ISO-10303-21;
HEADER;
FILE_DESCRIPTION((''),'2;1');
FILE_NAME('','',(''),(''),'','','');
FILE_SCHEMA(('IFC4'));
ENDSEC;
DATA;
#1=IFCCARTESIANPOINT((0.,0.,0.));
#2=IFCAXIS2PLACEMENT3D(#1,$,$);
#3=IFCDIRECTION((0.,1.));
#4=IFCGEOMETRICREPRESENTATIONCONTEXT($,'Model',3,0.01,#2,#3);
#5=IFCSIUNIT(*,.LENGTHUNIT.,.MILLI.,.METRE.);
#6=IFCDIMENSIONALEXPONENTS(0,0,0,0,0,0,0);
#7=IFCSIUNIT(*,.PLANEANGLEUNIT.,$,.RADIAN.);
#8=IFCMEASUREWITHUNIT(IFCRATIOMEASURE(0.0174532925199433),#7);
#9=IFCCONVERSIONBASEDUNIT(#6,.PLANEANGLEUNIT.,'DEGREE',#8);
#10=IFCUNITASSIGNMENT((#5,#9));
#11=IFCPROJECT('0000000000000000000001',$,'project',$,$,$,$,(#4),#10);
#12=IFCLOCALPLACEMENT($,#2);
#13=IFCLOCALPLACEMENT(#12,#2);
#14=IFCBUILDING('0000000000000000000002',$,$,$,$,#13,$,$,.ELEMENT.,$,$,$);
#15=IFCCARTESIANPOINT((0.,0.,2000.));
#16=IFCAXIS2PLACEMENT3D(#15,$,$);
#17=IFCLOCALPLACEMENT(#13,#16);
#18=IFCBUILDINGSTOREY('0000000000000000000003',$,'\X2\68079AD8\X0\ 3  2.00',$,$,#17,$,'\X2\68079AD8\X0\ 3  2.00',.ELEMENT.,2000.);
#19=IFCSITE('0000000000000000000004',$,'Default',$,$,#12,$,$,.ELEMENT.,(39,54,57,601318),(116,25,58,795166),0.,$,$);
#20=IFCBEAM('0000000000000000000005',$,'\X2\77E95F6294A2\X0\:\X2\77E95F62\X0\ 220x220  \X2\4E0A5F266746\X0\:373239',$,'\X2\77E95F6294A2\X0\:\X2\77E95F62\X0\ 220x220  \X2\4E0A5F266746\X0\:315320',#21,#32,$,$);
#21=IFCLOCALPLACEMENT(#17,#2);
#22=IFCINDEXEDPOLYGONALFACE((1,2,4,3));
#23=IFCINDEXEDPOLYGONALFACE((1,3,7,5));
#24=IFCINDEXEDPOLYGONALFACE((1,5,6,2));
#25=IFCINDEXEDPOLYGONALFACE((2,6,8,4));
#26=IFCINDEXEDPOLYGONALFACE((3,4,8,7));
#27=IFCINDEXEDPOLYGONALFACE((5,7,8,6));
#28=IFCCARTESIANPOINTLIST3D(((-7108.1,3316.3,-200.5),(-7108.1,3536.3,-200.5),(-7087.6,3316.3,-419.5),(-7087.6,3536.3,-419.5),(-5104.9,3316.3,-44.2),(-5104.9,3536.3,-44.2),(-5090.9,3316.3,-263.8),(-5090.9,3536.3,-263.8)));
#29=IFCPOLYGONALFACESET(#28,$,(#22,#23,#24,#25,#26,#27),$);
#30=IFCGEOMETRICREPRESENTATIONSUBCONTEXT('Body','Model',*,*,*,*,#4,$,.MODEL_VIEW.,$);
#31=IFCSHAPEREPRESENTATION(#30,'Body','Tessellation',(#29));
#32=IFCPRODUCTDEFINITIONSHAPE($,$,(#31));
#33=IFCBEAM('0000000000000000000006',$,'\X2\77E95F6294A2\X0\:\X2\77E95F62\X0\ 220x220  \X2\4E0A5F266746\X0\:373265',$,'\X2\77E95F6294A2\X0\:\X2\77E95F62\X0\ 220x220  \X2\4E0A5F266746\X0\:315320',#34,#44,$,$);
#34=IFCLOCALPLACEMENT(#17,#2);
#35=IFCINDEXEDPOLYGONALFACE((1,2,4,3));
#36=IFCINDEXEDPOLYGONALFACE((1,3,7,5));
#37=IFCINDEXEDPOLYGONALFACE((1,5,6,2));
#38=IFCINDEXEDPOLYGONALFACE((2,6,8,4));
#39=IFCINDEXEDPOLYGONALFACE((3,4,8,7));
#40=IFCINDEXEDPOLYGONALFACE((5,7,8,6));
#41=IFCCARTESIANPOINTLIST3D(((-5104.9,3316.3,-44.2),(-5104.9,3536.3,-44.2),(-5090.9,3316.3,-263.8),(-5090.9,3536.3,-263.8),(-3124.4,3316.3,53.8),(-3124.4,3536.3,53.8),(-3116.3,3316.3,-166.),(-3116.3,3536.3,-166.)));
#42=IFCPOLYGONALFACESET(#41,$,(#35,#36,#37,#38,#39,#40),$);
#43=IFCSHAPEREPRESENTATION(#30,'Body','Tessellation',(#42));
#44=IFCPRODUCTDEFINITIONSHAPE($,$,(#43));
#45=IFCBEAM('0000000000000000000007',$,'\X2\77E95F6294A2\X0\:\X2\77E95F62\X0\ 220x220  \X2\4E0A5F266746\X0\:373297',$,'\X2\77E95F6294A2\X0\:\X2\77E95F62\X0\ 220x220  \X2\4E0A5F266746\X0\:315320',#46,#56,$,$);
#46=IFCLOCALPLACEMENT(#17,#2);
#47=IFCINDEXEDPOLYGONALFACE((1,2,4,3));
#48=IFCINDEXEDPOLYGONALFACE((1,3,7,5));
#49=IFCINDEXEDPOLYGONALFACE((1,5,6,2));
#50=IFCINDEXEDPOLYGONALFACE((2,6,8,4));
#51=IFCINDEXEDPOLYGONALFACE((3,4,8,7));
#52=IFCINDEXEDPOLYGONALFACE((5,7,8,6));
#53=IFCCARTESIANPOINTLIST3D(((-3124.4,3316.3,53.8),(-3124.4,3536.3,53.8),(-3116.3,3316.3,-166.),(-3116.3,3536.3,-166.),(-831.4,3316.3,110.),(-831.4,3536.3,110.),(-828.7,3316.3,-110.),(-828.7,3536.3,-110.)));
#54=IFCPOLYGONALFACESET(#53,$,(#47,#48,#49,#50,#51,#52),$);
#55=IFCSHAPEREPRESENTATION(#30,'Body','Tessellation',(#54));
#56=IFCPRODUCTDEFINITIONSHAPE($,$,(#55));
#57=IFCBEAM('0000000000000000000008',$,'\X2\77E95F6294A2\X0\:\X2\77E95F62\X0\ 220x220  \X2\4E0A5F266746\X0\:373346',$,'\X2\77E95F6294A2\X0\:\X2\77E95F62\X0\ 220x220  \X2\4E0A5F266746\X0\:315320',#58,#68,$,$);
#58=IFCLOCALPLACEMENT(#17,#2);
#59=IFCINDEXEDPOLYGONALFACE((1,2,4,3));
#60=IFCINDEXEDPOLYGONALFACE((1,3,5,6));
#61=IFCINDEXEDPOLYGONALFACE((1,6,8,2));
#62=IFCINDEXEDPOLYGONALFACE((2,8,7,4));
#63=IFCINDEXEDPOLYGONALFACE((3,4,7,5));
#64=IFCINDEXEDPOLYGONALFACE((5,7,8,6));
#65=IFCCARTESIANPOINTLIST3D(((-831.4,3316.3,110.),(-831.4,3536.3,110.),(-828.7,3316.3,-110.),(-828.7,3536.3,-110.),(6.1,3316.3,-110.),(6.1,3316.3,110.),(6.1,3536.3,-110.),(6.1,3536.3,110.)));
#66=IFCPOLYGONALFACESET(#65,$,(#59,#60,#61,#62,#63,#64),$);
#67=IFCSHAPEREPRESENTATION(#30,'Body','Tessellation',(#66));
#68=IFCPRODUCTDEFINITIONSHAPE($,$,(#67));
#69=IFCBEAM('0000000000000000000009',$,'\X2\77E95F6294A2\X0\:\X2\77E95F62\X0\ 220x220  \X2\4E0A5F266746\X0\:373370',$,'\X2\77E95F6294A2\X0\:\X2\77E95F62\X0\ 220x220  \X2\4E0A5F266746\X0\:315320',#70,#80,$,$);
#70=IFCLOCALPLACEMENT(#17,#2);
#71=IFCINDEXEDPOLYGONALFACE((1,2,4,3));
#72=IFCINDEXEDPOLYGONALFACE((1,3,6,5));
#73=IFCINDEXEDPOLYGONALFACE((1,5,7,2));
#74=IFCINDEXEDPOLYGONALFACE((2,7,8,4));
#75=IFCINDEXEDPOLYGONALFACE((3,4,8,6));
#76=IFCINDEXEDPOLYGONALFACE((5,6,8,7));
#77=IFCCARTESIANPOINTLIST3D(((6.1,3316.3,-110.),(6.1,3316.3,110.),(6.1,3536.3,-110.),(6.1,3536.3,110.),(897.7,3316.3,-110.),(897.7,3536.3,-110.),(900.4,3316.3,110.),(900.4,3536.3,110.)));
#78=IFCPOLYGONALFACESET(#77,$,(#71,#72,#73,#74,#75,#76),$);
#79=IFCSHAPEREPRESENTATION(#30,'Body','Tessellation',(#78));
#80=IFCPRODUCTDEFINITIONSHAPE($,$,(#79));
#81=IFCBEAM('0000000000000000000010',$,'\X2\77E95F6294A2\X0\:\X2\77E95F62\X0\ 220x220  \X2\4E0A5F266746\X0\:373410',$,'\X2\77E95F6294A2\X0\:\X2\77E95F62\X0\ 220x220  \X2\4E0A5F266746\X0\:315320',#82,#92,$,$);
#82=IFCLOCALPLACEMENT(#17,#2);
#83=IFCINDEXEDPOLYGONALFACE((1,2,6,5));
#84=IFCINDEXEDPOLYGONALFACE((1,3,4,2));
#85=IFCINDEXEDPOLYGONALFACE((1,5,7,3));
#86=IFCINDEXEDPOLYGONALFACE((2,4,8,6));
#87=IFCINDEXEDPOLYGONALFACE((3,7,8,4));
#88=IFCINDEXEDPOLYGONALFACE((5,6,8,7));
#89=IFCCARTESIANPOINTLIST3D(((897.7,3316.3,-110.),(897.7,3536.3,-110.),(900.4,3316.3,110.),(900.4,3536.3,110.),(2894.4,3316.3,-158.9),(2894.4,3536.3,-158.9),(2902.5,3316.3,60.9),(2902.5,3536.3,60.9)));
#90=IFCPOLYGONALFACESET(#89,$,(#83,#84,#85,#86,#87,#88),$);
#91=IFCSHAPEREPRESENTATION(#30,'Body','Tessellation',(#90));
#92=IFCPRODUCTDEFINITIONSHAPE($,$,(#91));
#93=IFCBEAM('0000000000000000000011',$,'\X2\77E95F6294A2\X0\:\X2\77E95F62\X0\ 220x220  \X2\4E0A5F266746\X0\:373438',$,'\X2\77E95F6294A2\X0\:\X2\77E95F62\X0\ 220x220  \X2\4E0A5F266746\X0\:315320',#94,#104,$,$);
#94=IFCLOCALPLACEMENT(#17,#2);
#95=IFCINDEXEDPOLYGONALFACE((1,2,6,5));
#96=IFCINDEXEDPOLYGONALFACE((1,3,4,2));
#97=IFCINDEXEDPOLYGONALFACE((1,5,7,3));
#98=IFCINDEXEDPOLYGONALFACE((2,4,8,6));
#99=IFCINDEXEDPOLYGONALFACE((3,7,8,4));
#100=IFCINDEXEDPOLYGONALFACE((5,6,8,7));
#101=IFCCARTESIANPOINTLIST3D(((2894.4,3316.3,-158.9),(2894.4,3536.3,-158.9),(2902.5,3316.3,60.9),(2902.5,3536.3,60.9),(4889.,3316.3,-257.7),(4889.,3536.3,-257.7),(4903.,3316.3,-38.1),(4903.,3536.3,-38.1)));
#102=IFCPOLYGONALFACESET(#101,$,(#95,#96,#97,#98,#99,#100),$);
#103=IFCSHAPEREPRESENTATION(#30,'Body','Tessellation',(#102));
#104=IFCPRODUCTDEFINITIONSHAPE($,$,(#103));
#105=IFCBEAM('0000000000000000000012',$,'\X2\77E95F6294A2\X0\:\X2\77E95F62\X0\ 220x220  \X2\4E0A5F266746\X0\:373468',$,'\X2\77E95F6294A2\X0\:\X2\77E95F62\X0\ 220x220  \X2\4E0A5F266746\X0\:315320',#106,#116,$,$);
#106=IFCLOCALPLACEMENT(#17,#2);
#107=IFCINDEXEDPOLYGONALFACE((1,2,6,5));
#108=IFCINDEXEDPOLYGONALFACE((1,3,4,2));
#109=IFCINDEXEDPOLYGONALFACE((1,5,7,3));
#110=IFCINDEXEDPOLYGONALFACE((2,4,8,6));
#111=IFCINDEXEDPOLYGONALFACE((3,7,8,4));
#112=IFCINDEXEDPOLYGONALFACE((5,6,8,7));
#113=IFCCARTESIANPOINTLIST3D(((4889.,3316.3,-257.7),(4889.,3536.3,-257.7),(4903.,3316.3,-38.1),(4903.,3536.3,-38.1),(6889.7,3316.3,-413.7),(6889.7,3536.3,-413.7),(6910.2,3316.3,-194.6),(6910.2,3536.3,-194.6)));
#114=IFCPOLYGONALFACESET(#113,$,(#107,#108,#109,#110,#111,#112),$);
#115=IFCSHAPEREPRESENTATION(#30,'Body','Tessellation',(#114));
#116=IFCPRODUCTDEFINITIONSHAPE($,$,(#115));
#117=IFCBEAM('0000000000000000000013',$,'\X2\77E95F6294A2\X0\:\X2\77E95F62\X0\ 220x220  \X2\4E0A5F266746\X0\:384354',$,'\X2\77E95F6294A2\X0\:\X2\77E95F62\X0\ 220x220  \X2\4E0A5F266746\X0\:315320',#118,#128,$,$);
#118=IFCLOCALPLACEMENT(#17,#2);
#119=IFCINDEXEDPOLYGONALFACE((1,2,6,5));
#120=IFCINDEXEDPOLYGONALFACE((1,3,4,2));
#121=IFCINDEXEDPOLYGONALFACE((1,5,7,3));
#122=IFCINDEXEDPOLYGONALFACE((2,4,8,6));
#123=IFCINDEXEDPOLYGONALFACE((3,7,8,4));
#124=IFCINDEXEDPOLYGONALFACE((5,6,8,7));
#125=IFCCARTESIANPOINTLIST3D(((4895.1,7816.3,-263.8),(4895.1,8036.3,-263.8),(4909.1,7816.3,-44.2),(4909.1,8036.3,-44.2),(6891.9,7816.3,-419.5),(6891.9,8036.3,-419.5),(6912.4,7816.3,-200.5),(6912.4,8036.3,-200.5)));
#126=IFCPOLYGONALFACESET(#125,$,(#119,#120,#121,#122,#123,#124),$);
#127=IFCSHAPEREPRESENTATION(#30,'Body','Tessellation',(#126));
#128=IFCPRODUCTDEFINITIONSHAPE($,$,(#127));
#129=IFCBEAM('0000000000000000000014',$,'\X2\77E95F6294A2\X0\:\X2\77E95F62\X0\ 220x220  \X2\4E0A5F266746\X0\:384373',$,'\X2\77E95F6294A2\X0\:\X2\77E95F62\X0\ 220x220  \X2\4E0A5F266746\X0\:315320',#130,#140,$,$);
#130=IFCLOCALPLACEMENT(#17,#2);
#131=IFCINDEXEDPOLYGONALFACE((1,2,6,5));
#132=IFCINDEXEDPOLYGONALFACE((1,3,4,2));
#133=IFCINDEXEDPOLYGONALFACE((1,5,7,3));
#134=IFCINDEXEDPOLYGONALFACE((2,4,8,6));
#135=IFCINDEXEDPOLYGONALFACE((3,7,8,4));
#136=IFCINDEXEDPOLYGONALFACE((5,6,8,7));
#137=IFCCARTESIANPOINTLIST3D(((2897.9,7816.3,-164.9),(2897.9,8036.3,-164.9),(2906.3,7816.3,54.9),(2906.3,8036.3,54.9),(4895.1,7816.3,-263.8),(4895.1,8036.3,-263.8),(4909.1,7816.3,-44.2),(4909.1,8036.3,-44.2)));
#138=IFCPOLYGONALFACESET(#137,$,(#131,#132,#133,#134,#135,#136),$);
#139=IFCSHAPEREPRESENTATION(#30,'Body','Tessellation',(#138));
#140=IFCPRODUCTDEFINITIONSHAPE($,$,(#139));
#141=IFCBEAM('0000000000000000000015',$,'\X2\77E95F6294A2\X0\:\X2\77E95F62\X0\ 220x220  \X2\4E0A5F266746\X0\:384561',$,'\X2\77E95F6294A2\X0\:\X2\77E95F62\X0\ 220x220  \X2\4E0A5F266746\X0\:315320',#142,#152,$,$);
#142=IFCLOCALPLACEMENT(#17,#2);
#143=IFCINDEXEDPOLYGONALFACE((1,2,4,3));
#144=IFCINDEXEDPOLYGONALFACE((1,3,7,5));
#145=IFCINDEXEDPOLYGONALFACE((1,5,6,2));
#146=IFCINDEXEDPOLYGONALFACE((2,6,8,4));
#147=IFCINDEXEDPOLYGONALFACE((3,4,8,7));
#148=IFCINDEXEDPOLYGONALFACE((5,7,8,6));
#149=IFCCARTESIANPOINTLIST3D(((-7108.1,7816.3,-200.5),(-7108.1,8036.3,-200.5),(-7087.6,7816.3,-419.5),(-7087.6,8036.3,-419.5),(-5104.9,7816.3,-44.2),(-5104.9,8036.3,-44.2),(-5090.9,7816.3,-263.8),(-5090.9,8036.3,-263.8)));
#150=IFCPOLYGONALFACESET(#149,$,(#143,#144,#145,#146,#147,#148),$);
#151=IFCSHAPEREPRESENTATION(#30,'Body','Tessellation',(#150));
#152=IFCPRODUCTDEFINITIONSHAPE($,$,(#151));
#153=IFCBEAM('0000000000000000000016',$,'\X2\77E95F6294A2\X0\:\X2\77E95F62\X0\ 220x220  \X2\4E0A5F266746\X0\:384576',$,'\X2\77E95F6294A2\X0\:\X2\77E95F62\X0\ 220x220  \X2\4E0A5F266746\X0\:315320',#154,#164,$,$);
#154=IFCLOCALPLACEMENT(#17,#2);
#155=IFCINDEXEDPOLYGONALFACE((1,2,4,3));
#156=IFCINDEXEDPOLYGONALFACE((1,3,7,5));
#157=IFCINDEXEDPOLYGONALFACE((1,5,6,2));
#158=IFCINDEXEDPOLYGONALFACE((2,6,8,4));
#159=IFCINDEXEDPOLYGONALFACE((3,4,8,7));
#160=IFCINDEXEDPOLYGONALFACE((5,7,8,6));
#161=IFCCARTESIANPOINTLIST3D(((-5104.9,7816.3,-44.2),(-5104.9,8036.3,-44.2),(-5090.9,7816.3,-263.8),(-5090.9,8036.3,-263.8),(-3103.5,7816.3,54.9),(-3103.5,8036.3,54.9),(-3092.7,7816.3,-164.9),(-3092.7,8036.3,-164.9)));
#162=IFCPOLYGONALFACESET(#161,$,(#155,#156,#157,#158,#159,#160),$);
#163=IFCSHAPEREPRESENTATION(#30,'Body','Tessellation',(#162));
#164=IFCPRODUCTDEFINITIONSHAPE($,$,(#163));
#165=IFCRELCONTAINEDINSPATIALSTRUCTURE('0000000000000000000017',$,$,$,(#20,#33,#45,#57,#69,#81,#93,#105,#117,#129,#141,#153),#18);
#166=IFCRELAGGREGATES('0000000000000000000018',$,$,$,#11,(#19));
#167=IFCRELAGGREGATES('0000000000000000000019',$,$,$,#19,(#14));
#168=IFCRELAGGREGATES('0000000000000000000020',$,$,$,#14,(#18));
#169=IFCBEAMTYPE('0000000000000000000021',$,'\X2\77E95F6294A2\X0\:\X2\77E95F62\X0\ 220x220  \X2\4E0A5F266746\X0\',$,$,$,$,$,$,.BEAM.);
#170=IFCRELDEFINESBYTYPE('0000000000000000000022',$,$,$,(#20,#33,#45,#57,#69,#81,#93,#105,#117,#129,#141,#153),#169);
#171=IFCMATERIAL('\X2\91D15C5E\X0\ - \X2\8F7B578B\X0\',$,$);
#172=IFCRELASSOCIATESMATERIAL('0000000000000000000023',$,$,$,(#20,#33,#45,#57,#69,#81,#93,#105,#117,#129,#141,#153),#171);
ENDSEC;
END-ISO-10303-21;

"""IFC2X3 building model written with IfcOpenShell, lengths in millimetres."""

from ifc_helpers import new_model, entity, si_unit, converted_unit, direction, frame, frame_2d, origin, origin_2d_with_axis, place, context, subcontext, project, spatial, rectangle, extrude, clip, halfspace, material, type_object, element, save


model = new_model("IFC2X3")

# Units and contexts
model_context = context("Model", 3, precision=0.01, world=origin(), true_north=direction((0.0, 1.0)))
body_context = subcontext(model_context, "Body", "Model", "MODEL_VIEW")
ifc_project = project(units=[si_unit("LENGTHUNIT", "METRE", prefix="MILLI"), converted_unit("PLANEANGLEUNIT", "DEGREE", entity("IfcRatioMeasure", 0.0174532925199433), si_unit("PLANEANGLEUNIT", "RADIAN"), dimensions=[0, 0, 0, 0, 0, 0, 0])], contexts=[model_context])

# Site, building, storey
site_placement = place(None, origin())
site = spatial("IfcSite", under=ifc_project, at=site_placement, Name="Default", CompositionType="ELEMENT", RefLatitude=(39, 54, 57, 601318), RefLongitude=(116, 25, 58, 795166), RefElevation=0.0)
building_placement = place(site_placement, origin())
building = spatial("IfcBuilding", under=site, at=building_placement, CompositionType="ELEMENT")
storey_placement = place(building_placement, frame((0.0, 0.0, 2000.0)))
storey = spatial("IfcBuildingStorey", under=building, at=storey_placement, Name="标高 3  2.00", LongName="标高 3  2.00", CompositionType="ELEMENT", Elevation=2000.0)

# Beams
ifc_material = material(Name="金属 - 轻型")
beam_type = type_object("IfcBeamType", Name="矩形钢:矩形 220x220  上弦杆", PredefinedType="BEAM")
beam_1_placement = place(storey_placement, frame((-7097.9, 3426.3, -310.0), z_axis=(-0.077764, 0.0, 0.996972), x_axis=(0.996972, 0.0, 0.077764)))
element("IfcBeam", 1, at=beam_1_placement, inside=storey, type_object=beam_type, material=ifc_material, Name="矩形钢:矩形 220x220  上弦杆:373239", ObjectType="矩形钢:矩形 220x220  上弦杆:315320", context=body_context, shape_type="Clipping", body=[
    clip(clip(extrude(rectangle(XDim=220.0, YDim=220.0, at=frame_2d((0.0, 0.0), x_axis=(1.0, 0.0))), frame((-1.7, 0.0, 0.0), z_axis=(1.0, 0.0, 0.0), x_axis=(0.0, 0.0, -1.0)), (0.0, 0.0, 1.0), 2009.3), halfspace(frame((2007.6, 0.0, 110.0), z_axis=(0.999899, 0.0, -0.014191), x_axis=(-0.014191, 0.0, -0.999899)), False)), halfspace(frame((-1.7, 0.0, 110.0), z_axis=(-0.999878, 0.0, -0.015611), x_axis=(0.015611, 0.0, -0.999878)), False)),
])
beam_2_placement = place(storey_placement, frame((-5097.9, 3426.3, -154.0), z_axis=(-0.049439, 0.0, 0.998777), x_axis=(0.998777, 0.0, 0.049439)))
element("IfcBeam", 2, at=beam_2_placement, inside=storey, type_object=beam_type, material=ifc_material, Name="矩形钢:矩形 220x220  上弦杆:373265", ObjectType="矩形钢:矩形 220x220  上弦杆:315320", context=body_context, shape_type="Clipping", body=[
    clip(clip(extrude(rectangle(XDim=220.0, YDim=220.0, at=frame_2d((0.0, 0.0), x_axis=(1.0, 0.0))), frame((-1.6, 0.0, 0.0), z_axis=(1.0, 0.0, 0.0), x_axis=(0.0, 0.0, -1.0)), (0.0, 0.0, 1.0), 1982.9), halfspace(frame((1981.4, 0.0, 110.0), z_axis=(0.999922, 0.0, -0.012482), x_axis=(-0.012482, 0.0, -0.999922)), False)), halfspace(frame((-1.6, 0.0, 110.0), z_axis=(-0.999899, 0.0, -0.014191), x_axis=(0.014191, 0.0, -0.999899)), False)),
])
beam_3_placement = place(storey_placement, frame((-3120.3, 3426.3, -56.1), z_axis=(-0.024493, 0.0, 0.9997), x_axis=(0.9997, 0.0, 0.024493)))
element("IfcBeam", 3, at=beam_3_placement, inside=storey, type_object=beam_type, material=ifc_material, Name="矩形钢:矩形 220x220  上弦杆:373297", ObjectType="矩形钢:矩形 220x220  上弦杆:315320", context=body_context, shape_type="Clipping", body=[
    clip(clip(extrude(rectangle(XDim=220.0, YDim=220.0, at=frame_2d((0.0, 0.0), x_axis=(1.0, 0.0))), frame((-1.4, 0.0, 0.0), z_axis=(1.0, 0.0, 0.0), x_axis=(0.0, 0.0, -1.0)), (0.0, 0.0, 1.0), 2293.7), halfspace(frame((2292.4, 0.0, 110.0), z_axis=(0.999925, 0.0, -0.012247), x_axis=(-0.012247, 0.0, -0.999925)), False)), halfspace(frame((-1.4, 0.0, 110.0), z_axis=(-0.999922, 0.0, -0.012482), x_axis=(0.012482, 0.0, -0.999922)), False)),
])
beam_4_placement = place(storey_placement, frame((-1100.9, 3426.3, 0.0)))
element("IfcBeam", 4, at=beam_4_placement, inside=storey, type_object=beam_type, material=ifc_material, Name="矩形钢:矩形 220x220  上弦杆:373346", ObjectType="矩形钢:矩形 220x220  上弦杆:315320", context=body_context, shape_type="Clipping", body=[
    clip(extrude(rectangle(XDim=220.0, YDim=220.0, at=frame_2d((0.0, 0.0), x_axis=(1.0, 0.0))), frame((269.6, 0.0, 0.0), z_axis=(1.0, 0.0, 0.0), x_axis=(0.0, 0.0, -1.0)), (0.0, 0.0, 1.0), 837.4), halfspace(frame((269.6, 0.0, 110.0), z_axis=(-0.999925, 0.0, -0.012247), x_axis=(0.012247, 0.0, -0.999925)), False)),
])
beam_5_placement = place(storey_placement, frame((-80.9, 3426.3, 0.0)))
element("IfcBeam", 5, at=beam_5_placement, inside=storey, type_object=beam_type, material=ifc_material, Name="矩形钢:矩形 220x220  上弦杆:373370", ObjectType="矩形钢:矩形 220x220  上弦杆:315320", context=body_context, shape_type="Clipping", body=[
    clip(extrude(rectangle(XDim=220.0, YDim=220.0, at=frame_2d((0.0, 0.0), x_axis=(1.0, 0.0))), frame((87.0, 0.0, 0.0), z_axis=(1.0, 0.0, 0.0), x_axis=(0.0, 0.0, -1.0)), (0.0, 0.0, 1.0), 894.3), halfspace(frame((981.3, 0.0, 110.0), z_axis=(0.999925, 0.0, -0.012247), x_axis=(0.012247, 0.0, 0.999925)), False)),
])
beam_6_placement = place(storey_placement, frame((899.1, 3426.3, 0.0), z_axis=(0.024493, 0.0, 0.9997), x_axis=(0.9997, 0.0, -0.024493)))
element("IfcBeam", 6, at=beam_6_placement, inside=storey, type_object=beam_type, material=ifc_material, Name="矩形钢:矩形 220x220  上弦杆:373410", ObjectType="矩形钢:矩形 220x220  上弦杆:315320", context=body_context, shape_type="Clipping", body=[
    clip(clip(extrude(rectangle(XDim=220.0, YDim=220.0, at=frame_2d((0.0, 0.0), x_axis=(1.0, 0.0))), frame((-1.3, 0.0, 0.0), z_axis=(1.0, 0.0, 0.0), x_axis=(0.0, 0.0, -1.0)), (0.0, 0.0, 1.0), 2002.7), halfspace(frame((2001.4, 0.0, 110.0), z_axis=(0.999922, 0.0, -0.012482), x_axis=(0.012482, 0.0, 0.999922)), False)), halfspace(frame((-1.3, 0.0, 110.0), z_axis=(-0.999925, 0.0, -0.012247), x_axis=(-0.012247, 0.0, 0.999925)), False)),
])
beam_7_placement = place(storey_placement, frame((2898.5, 3426.3, -49.0), z_axis=(0.049439, 0.0, 0.998777), x_axis=(0.998777, 0.0, -0.049439)))
element("IfcBeam", 7, at=beam_7_placement, inside=storey, type_object=beam_type, material=ifc_material, Name="矩形钢:矩形 220x220  上弦杆:373438", ObjectType="矩形钢:矩形 220x220  上弦杆:315320", context=body_context, shape_type="Clipping", body=[
    clip(clip(extrude(rectangle(XDim=220.0, YDim=220.0, at=frame_2d((0.0, 0.0), x_axis=(1.0, 0.0))), frame((-1.4, 0.0, 0.0), z_axis=(1.0, 0.0, 0.0), x_axis=(0.0, 0.0, -1.0)), (0.0, 0.0, 1.0), 2002.9), halfspace(frame((2001.6, 0.0, 110.0), z_axis=(0.999899, 0.0, -0.014191), x_axis=(0.014191, 0.0, 0.999899)), False)), halfspace(frame((-1.4, 0.0, 110.0), z_axis=(-0.999922, 0.0, -0.012482), x_axis=(-0.012482, 0.0, 0.999922)), False)),
])
beam_8_placement = place(storey_placement, frame((4896.0, 3426.3, -147.9), z_axis=(0.077764, 0.0, 0.996972), x_axis=(0.996972, 0.0, -0.077764)))
element("IfcBeam", 8, at=beam_8_placement, inside=storey, type_object=beam_type, material=ifc_material, Name="矩形钢:矩形 220x220  上弦杆:373468", ObjectType="矩形钢:矩形 220x220  上弦杆:315320", context=body_context, shape_type="Clipping", body=[
    clip(clip(extrude(rectangle(XDim=220.0, YDim=220.0, at=frame_2d((0.0, 0.0), x_axis=(1.0, 0.0))), frame((-1.6, 0.0, 0.0), z_axis=(1.0, 0.0, 0.0), x_axis=(0.0, 0.0, -1.0)), (0.0, 0.0, 1.0), 2013.3), halfspace(frame((2011.7, 0.0, 110.0), z_axis=(0.999878, 0.0, -0.015611), x_axis=(0.015611, 0.0, 0.999878)), False)), halfspace(frame((-1.6, 0.0, 110.0), z_axis=(-0.999899, 0.0, -0.014191), x_axis=(-0.014191, 0.0, 0.999899)), False)),
])
beam_9_placement = place(storey_placement, frame((6902.1, 7926.3, -310.0), z_axis=(0.077764, 0.0, 0.996972), x_axis=(-0.996972, 0.0, 0.077764)))
element("IfcBeam", 9, at=beam_9_placement, inside=storey, type_object=beam_type, material=ifc_material, Name="矩形钢:矩形 220x220  上弦杆:384354", ObjectType="矩形钢:矩形 220x220  上弦杆:315320", context=body_context, shape_type="Clipping", body=[
    clip(clip(extrude(rectangle(XDim=220.0, YDim=220.0, at=origin_2d_with_axis()), frame((-1.7, 0.0, 0.0), z_axis=(1.0, 0.0, 0.0), x_axis=(0.0, 0.0, -1.0)), (0.0, 0.0, 1.0), 2009.4), halfspace(frame((-1.7, 0.0, 110.0), z_axis=(-0.999878, 0.0, -0.015611), x_axis=(-0.015611, 0.0, 0.999878)), False)), halfspace(frame((2007.6, 0.0, 110.0), z_axis=(0.999899, 0.0, -0.014191), x_axis=(0.014191, 0.0, 0.999899)), False)),
])
beam_10_placement = place(storey_placement, frame((4902.1, 7926.3, -154.0), z_axis=(0.049439, 0.0, 0.998777), x_axis=(-0.998777, 0.0, 0.049439)))
element("IfcBeam", 10, at=beam_10_placement, inside=storey, type_object=beam_type, material=ifc_material, Name="矩形钢:矩形 220x220  上弦杆:384373", ObjectType="矩形钢:矩形 220x220  上弦杆:315320", context=body_context, shape_type="Clipping", body=[
    clip(clip(extrude(rectangle(XDim=220.0, YDim=220.0, at=frame_2d((0.0, 0.0), x_axis=(1.0, 0.0))), frame((-1.6, 0.0, 0.0), z_axis=(1.0, 0.0, 0.0), x_axis=(0.0, 0.0, -1.0)), (0.0, 0.0, 1.0), 2005.2), halfspace(frame((2001.2, 0.0, -110.0), z_axis=(0.999937, 0.0, -0.01122), x_axis=(0.01122, 0.0, 0.999937)), False)), halfspace(frame((-1.6, 0.0, 110.0), z_axis=(-0.999899, 0.0, -0.014191), x_axis=(-0.014191, 0.0, 0.999899)), False)),
])
beam_11_placement = place(storey_placement, frame((-7097.9, 7926.3, -310.0), z_axis=(-0.077764, 0.0, 0.996972), x_axis=(0.996972, 0.0, 0.077764)))
element("IfcBeam", 11, at=beam_11_placement, inside=storey, type_object=beam_type, material=ifc_material, Name="矩形钢:矩形 220x220  上弦杆:384561", ObjectType="矩形钢:矩形 220x220  上弦杆:315320", context=body_context, shape_type="Clipping", body=[
    clip(clip(extrude(rectangle(XDim=220.0, YDim=220.0, at=frame_2d((0.0, 0.0), x_axis=(1.0, 0.0))), frame((-1.7, 0.0, 0.0), z_axis=(1.0, 0.0, 0.0), x_axis=(0.0, 0.0, -1.0)), (0.0, 0.0, 1.0), 2009.4), halfspace(frame((2007.6, 0.0, 110.0), z_axis=(0.999899, 0.0, -0.014191), x_axis=(-0.014191, 0.0, -0.999899)), False)), halfspace(frame((-1.7, 0.0, 110.0), z_axis=(-0.999878, 0.0, -0.015611), x_axis=(0.015611, 0.0, -0.999878)), False)),
])
beam_12_placement = place(storey_placement, frame((-5097.9, 7926.3, -154.0), z_axis=(-0.049439, 0.0, 0.998777), x_axis=(0.998777, 0.0, 0.049439)))
element("IfcBeam", 12, at=beam_12_placement, inside=storey, type_object=beam_type, material=ifc_material, Name="矩形钢:矩形 220x220  上弦杆:384576", ObjectType="矩形钢:矩形 220x220  上弦杆:315320", context=body_context, shape_type="Clipping", body=[
    clip(extrude(rectangle(XDim=220.0, YDim=220.0, at=frame_2d((0.0, 0.0), x_axis=(1.0, 0.0))), frame((-1.6, 0.0, 0.0), z_axis=(1.0, 0.0, 0.0), x_axis=(0.0, 0.0, -1.0)), (0.0, 0.0, 1.0), 2003.8), halfspace(frame((-1.6, 0.0, 110.0), z_axis=(-0.999899, 0.0, -0.014191), x_axis=(0.014191, 0.0, -0.999899)), False)),
])

save(model, "model.ifc")
